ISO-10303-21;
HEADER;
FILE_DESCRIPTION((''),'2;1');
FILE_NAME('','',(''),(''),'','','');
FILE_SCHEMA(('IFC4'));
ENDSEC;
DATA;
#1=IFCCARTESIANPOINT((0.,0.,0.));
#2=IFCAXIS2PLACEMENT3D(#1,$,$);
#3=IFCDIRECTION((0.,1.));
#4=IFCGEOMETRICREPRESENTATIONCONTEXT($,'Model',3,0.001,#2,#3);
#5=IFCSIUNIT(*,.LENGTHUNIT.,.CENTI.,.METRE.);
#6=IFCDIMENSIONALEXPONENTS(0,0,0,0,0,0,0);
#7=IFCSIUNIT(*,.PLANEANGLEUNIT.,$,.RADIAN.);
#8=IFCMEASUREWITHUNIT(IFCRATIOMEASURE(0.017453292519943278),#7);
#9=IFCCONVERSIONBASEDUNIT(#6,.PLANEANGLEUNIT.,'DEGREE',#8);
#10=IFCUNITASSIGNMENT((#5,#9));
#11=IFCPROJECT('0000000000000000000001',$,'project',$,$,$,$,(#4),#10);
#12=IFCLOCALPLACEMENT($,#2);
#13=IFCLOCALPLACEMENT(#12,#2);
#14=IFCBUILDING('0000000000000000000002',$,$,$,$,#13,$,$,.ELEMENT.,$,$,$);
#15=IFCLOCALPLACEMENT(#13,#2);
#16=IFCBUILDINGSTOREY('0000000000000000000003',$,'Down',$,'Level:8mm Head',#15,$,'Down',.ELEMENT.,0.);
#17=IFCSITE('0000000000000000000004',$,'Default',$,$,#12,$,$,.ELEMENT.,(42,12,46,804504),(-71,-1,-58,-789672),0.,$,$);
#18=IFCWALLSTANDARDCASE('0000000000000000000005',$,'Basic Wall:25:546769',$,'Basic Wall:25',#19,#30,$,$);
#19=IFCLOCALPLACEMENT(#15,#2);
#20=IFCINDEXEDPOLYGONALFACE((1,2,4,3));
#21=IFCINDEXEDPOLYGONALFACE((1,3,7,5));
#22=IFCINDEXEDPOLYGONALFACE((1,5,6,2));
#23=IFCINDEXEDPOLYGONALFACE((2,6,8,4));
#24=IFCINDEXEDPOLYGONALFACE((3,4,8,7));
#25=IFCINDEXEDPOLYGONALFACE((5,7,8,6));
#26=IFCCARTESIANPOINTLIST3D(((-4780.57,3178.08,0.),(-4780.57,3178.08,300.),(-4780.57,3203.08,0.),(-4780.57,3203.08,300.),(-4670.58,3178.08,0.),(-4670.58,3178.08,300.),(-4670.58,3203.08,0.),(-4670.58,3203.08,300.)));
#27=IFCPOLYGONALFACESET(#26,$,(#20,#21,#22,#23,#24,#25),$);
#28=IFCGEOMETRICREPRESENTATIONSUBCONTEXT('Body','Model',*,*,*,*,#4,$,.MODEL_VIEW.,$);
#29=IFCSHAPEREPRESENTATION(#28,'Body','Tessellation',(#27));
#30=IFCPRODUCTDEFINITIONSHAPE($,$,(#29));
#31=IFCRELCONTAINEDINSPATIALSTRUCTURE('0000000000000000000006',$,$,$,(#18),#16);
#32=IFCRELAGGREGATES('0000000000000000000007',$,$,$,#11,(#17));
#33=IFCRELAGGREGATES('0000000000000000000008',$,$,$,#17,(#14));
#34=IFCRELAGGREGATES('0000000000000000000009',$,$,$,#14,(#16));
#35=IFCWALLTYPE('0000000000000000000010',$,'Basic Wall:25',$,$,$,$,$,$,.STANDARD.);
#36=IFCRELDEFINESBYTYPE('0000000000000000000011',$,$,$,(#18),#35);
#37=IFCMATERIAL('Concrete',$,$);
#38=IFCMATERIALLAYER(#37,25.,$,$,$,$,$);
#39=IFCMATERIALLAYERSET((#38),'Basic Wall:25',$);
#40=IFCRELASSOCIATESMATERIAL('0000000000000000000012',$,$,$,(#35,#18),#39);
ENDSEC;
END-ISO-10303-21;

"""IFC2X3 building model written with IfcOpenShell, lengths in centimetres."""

from ifc_helpers import new_model, entity, si_unit, converted_unit, direction, frame, frame_2d, origin, place, context, subcontext, project, spatial, rectangle, extrude, material, layer, layer_set, layer_usage, type_object, element, save


model = new_model("IFC2X3")

# Units and contexts
model_context = context("Model", 3, precision=0.001, world=origin(), true_north=direction((0.0, 1.0)))
body_context = subcontext(model_context, "Body", "Model", "MODEL_VIEW")
ifc_project = project(units=[si_unit("LENGTHUNIT", "METRE", prefix="CENTI"), converted_unit("PLANEANGLEUNIT", "DEGREE", entity("IfcRatioMeasure", 0.017453292519943278), si_unit("PLANEANGLEUNIT", "RADIAN"), dimensions=[0, 0, 0, 0, 0, 0, 0])], contexts=[model_context])

# Site, building, storey
site_placement = place(None, origin())
site = spatial("IfcSite", under=ifc_project, at=site_placement, Name="Default", CompositionType="ELEMENT", RefLatitude=(42, 12, 46, 804504), RefLongitude=(-71, -1, -58, -789672), RefElevation=0.0)
building_placement = place(site_placement, origin())
building = spatial("IfcBuilding", under=site, at=building_placement, CompositionType="ELEMENT")
storey_placement = place(building_placement, origin())
storey = spatial("IfcBuildingStorey", under=building, at=storey_placement, Name="Down", ObjectType="Level:8mm Head", LongName="Down", CompositionType="ELEMENT", Elevation=0.0)

# Wall
ifc_material = material(Name="Concrete")
ifc_layer_1 = layer(ifc_material, 25.0)
ifc_layer_set_1 = layer_set([ifc_layer_1], Name="Basic Wall:25")
ifc_layer_usage_1 = layer_usage(ifc_layer_set_1, "AXIS2", "POSITIVE", -12.5)
wall_type_1 = type_object("IfcWallType", Name="Basic Wall:25", PredefinedType="STANDARD", material=ifc_layer_set_1)
wall_1_placement = place(storey_placement, frame((-4780.57, 3190.58, 0.0)))
element("IfcWallStandardCase", 1, at=wall_1_placement, inside=storey, type_object=wall_type_1, material=ifc_layer_usage_1, Name="Basic Wall:25:546769", ObjectType="Basic Wall:25", context=body_context, shape_type="SweptSolid", body=[
    extrude(rectangle(XDim=109.99, YDim=25.0, at=frame_2d((55.0, 0.0), x_axis=(-1.0, 0.0))), origin(), (0.0, 0.0, 1.0), 300.0),
])

save(model, "model.ifc")
